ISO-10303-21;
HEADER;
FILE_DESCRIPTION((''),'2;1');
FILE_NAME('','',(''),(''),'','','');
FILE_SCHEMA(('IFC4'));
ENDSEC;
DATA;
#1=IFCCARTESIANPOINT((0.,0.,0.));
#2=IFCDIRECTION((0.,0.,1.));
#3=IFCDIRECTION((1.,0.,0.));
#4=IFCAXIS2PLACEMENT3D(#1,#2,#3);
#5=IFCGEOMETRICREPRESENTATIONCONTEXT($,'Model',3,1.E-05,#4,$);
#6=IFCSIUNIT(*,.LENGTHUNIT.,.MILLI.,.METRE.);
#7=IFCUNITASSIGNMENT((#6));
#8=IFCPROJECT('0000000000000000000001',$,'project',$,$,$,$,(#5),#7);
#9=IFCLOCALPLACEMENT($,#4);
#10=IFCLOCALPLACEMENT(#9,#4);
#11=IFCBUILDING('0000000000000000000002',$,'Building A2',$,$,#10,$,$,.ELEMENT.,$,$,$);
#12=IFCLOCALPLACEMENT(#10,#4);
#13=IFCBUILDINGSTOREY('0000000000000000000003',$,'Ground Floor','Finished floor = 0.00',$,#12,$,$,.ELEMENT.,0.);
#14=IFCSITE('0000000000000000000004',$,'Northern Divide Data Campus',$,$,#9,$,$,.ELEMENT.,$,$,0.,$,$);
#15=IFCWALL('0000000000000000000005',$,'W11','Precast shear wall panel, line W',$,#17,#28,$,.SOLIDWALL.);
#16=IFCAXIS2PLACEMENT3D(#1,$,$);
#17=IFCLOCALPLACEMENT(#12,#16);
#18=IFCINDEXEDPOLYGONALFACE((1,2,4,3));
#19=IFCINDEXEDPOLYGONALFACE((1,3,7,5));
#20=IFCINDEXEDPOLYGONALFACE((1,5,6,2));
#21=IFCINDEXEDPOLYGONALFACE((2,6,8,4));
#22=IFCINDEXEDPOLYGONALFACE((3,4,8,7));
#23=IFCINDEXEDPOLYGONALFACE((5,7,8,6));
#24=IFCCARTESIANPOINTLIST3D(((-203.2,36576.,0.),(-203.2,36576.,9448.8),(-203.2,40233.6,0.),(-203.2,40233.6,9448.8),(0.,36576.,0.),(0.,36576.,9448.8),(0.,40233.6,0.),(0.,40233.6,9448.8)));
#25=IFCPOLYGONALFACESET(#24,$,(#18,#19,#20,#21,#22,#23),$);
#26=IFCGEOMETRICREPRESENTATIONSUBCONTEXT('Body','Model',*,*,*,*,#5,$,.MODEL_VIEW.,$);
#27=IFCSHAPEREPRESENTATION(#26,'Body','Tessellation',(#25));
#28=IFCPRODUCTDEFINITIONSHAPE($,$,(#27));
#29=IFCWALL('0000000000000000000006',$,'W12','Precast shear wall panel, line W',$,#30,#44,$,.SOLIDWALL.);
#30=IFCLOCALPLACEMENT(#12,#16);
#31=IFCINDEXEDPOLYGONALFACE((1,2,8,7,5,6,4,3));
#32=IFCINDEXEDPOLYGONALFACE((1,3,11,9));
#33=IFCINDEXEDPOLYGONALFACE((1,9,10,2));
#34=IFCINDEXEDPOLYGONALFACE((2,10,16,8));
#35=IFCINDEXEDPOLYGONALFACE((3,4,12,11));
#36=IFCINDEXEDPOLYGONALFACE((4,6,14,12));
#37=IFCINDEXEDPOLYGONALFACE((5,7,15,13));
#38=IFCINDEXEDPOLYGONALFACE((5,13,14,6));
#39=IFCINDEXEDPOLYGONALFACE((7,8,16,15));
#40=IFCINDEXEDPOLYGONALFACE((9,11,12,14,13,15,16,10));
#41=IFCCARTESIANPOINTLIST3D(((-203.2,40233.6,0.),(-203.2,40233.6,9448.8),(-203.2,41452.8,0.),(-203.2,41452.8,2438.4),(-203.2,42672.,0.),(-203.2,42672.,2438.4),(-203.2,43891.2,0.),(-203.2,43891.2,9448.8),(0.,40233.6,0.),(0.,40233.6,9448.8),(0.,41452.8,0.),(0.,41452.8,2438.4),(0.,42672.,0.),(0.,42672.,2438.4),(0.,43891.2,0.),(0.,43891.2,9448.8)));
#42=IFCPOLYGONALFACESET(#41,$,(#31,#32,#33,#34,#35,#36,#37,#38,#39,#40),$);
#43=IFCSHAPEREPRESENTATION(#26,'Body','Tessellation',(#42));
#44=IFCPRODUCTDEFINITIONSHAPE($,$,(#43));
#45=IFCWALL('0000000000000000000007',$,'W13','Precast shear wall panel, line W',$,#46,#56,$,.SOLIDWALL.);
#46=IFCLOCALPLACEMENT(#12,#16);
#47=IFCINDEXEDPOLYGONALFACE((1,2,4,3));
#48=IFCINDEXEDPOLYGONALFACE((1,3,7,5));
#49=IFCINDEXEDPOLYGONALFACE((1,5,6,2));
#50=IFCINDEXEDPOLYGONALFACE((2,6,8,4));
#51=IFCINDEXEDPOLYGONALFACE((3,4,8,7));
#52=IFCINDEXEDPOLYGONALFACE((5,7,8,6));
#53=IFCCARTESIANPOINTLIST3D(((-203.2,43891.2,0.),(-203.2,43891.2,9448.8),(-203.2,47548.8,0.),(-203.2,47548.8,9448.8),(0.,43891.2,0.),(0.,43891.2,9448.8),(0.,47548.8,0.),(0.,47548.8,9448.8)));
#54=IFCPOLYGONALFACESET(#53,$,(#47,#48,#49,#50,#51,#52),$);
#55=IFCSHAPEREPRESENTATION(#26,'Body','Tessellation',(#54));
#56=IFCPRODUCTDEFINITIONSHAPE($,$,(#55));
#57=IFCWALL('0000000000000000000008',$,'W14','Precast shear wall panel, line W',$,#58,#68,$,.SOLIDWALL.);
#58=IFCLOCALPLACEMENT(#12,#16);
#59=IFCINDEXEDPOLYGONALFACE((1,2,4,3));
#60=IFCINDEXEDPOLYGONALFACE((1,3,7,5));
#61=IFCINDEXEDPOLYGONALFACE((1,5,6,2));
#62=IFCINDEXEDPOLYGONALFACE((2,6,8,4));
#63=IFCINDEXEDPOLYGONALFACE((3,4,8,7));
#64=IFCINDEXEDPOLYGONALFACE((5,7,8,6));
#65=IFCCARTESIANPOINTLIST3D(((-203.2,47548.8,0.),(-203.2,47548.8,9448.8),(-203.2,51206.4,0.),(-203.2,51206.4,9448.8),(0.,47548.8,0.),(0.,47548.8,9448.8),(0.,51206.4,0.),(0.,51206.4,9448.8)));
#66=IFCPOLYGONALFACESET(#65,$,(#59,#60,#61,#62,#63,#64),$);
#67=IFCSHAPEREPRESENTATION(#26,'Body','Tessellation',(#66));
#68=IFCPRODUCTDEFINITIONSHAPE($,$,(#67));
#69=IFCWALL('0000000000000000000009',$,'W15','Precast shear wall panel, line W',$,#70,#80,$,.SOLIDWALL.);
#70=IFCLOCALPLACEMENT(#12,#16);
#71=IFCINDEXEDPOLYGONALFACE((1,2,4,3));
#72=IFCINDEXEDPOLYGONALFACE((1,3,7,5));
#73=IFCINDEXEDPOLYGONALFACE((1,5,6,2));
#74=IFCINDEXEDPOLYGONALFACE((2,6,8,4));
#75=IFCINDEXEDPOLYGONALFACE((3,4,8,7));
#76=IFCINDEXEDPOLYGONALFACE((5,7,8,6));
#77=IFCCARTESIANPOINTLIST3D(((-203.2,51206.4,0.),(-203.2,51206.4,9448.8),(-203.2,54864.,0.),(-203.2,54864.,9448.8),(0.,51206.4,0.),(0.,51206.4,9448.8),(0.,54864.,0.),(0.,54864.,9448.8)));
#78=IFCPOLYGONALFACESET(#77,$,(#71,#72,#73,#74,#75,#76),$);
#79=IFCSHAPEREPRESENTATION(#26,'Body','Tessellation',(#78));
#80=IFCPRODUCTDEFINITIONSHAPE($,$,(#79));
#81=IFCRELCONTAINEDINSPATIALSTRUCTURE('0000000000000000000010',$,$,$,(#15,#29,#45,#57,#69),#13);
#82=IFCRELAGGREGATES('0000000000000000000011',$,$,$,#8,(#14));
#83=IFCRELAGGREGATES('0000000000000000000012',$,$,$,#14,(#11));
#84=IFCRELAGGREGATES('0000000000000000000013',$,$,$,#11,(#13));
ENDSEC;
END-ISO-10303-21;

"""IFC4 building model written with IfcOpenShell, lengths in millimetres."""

from ifc_helpers import new_model, si_unit, origin, origin_with_axes, place, context, subcontext, project, spatial, polyline, outline, extrude, element, save


model = new_model("IFC4")

# Units and contexts
model_context = context("Model", 3, precision=1e-05, world=origin_with_axes())
body_context = subcontext(model_context, "Body", "Model", "MODEL_VIEW")
ifc_project = project(units=[si_unit("LENGTHUNIT", "METRE", prefix="MILLI")], contexts=[model_context])

# Site, building, storey
site_placement = place(None, origin_with_axes())
site = spatial("IfcSite", under=ifc_project, at=site_placement, Name="Northern Divide Data Campus", CompositionType="ELEMENT", RefElevation=0.0)
building_placement = place(site_placement, origin_with_axes())
building = spatial("IfcBuilding", under=site, at=building_placement, Name="Building A2", CompositionType="ELEMENT")
storey_placement = place(building_placement, origin_with_axes())
storey = spatial("IfcBuildingStorey", under=building, at=storey_placement, Name="Ground Floor", Description="Finished floor = 0.00", CompositionType="ELEMENT", Elevation=0.0)

# Wall
wall_1_placement = place(storey_placement, origin_with_axes())
element("IfcWall", 1, at=wall_1_placement, inside=storey, Name="W11", Description="Precast shear wall panel, line W", PredefinedType="SOLIDWALL", context=body_context, shape_type="SweptSolid", body=[
    extrude(outline(polyline([(-203.2, 36576.0), (0.0, 36576.0), (0.0, 40233.6), (-203.2, 40233.6), (-203.2, 36576.0)])), origin(), (0.0, 0.0, 1.0), 9448.8),
])

# Wall, opening
wall_2_placement = place(storey_placement, origin_with_axes())
wall_2 = element("IfcWall", 2, at=wall_2_placement, inside=storey, Name="W12", Description="Precast shear wall panel, line W", PredefinedType="SOLIDWALL", context=body_context, shape_type="SweptSolid", body=[
    extrude(outline(polyline([(-203.2, 40233.6), (0.0, 40233.6), (0.0, 43891.2), (-203.2, 43891.2), (-203.2, 40233.6)])), origin(), (0.0, 0.0, 1.0), 9448.8),
])
opening_1_placement = place(storey_placement, origin_with_axes())
element("IfcOpeningElement", 3, at=opening_1_placement, cuts=wall_2, PredefinedType="OPENING", context=body_context, shape_type="SweptSolid", body=[
    extrude(outline(polyline([(-203.2, 41452.8), (0.0, 41452.8), (0.0, 42672.0), (-203.2, 42672.0), (-203.2, 41452.8)])), origin_with_axes(), (0.0, 0.0, 1.0), 2438.4),
])

# Walls
wall_3_placement = place(storey_placement, origin_with_axes())
element("IfcWall", 4, at=wall_3_placement, inside=storey, Name="W13", Description="Precast shear wall panel, line W", PredefinedType="SOLIDWALL", context=body_context, shape_type="SweptSolid", body=[
    extrude(outline(polyline([(-203.2, 43891.2), (0.0, 43891.2), (0.0, 47548.8), (-203.2, 47548.8), (-203.2, 43891.2)])), origin(), (0.0, 0.0, 1.0), 9448.8),
])
wall_4_placement = place(storey_placement, origin_with_axes())
element("IfcWall", 5, at=wall_4_placement, inside=storey, Name="W14", Description="Precast shear wall panel, line W", PredefinedType="SOLIDWALL", context=body_context, shape_type="SweptSolid", body=[
    extrude(outline(polyline([(-203.2, 47548.8), (0.0, 47548.8), (0.0, 51206.4), (-203.2, 51206.4), (-203.2, 47548.8)])), origin(), (0.0, 0.0, 1.0), 9448.8),
])
wall_5_placement = place(storey_placement, origin_with_axes())
element("IfcWall", 6, at=wall_5_placement, inside=storey, Name="W15", Description="Precast shear wall panel, line W", PredefinedType="SOLIDWALL", context=body_context, shape_type="SweptSolid", body=[
    extrude(outline(polyline([(-203.2, 51206.4), (0.0, 51206.4), (0.0, 54864.0), (-203.2, 54864.0), (-203.2, 51206.4)])), origin(), (0.0, 0.0, 1.0), 9448.8),
])

save(model, "model.ifc")
